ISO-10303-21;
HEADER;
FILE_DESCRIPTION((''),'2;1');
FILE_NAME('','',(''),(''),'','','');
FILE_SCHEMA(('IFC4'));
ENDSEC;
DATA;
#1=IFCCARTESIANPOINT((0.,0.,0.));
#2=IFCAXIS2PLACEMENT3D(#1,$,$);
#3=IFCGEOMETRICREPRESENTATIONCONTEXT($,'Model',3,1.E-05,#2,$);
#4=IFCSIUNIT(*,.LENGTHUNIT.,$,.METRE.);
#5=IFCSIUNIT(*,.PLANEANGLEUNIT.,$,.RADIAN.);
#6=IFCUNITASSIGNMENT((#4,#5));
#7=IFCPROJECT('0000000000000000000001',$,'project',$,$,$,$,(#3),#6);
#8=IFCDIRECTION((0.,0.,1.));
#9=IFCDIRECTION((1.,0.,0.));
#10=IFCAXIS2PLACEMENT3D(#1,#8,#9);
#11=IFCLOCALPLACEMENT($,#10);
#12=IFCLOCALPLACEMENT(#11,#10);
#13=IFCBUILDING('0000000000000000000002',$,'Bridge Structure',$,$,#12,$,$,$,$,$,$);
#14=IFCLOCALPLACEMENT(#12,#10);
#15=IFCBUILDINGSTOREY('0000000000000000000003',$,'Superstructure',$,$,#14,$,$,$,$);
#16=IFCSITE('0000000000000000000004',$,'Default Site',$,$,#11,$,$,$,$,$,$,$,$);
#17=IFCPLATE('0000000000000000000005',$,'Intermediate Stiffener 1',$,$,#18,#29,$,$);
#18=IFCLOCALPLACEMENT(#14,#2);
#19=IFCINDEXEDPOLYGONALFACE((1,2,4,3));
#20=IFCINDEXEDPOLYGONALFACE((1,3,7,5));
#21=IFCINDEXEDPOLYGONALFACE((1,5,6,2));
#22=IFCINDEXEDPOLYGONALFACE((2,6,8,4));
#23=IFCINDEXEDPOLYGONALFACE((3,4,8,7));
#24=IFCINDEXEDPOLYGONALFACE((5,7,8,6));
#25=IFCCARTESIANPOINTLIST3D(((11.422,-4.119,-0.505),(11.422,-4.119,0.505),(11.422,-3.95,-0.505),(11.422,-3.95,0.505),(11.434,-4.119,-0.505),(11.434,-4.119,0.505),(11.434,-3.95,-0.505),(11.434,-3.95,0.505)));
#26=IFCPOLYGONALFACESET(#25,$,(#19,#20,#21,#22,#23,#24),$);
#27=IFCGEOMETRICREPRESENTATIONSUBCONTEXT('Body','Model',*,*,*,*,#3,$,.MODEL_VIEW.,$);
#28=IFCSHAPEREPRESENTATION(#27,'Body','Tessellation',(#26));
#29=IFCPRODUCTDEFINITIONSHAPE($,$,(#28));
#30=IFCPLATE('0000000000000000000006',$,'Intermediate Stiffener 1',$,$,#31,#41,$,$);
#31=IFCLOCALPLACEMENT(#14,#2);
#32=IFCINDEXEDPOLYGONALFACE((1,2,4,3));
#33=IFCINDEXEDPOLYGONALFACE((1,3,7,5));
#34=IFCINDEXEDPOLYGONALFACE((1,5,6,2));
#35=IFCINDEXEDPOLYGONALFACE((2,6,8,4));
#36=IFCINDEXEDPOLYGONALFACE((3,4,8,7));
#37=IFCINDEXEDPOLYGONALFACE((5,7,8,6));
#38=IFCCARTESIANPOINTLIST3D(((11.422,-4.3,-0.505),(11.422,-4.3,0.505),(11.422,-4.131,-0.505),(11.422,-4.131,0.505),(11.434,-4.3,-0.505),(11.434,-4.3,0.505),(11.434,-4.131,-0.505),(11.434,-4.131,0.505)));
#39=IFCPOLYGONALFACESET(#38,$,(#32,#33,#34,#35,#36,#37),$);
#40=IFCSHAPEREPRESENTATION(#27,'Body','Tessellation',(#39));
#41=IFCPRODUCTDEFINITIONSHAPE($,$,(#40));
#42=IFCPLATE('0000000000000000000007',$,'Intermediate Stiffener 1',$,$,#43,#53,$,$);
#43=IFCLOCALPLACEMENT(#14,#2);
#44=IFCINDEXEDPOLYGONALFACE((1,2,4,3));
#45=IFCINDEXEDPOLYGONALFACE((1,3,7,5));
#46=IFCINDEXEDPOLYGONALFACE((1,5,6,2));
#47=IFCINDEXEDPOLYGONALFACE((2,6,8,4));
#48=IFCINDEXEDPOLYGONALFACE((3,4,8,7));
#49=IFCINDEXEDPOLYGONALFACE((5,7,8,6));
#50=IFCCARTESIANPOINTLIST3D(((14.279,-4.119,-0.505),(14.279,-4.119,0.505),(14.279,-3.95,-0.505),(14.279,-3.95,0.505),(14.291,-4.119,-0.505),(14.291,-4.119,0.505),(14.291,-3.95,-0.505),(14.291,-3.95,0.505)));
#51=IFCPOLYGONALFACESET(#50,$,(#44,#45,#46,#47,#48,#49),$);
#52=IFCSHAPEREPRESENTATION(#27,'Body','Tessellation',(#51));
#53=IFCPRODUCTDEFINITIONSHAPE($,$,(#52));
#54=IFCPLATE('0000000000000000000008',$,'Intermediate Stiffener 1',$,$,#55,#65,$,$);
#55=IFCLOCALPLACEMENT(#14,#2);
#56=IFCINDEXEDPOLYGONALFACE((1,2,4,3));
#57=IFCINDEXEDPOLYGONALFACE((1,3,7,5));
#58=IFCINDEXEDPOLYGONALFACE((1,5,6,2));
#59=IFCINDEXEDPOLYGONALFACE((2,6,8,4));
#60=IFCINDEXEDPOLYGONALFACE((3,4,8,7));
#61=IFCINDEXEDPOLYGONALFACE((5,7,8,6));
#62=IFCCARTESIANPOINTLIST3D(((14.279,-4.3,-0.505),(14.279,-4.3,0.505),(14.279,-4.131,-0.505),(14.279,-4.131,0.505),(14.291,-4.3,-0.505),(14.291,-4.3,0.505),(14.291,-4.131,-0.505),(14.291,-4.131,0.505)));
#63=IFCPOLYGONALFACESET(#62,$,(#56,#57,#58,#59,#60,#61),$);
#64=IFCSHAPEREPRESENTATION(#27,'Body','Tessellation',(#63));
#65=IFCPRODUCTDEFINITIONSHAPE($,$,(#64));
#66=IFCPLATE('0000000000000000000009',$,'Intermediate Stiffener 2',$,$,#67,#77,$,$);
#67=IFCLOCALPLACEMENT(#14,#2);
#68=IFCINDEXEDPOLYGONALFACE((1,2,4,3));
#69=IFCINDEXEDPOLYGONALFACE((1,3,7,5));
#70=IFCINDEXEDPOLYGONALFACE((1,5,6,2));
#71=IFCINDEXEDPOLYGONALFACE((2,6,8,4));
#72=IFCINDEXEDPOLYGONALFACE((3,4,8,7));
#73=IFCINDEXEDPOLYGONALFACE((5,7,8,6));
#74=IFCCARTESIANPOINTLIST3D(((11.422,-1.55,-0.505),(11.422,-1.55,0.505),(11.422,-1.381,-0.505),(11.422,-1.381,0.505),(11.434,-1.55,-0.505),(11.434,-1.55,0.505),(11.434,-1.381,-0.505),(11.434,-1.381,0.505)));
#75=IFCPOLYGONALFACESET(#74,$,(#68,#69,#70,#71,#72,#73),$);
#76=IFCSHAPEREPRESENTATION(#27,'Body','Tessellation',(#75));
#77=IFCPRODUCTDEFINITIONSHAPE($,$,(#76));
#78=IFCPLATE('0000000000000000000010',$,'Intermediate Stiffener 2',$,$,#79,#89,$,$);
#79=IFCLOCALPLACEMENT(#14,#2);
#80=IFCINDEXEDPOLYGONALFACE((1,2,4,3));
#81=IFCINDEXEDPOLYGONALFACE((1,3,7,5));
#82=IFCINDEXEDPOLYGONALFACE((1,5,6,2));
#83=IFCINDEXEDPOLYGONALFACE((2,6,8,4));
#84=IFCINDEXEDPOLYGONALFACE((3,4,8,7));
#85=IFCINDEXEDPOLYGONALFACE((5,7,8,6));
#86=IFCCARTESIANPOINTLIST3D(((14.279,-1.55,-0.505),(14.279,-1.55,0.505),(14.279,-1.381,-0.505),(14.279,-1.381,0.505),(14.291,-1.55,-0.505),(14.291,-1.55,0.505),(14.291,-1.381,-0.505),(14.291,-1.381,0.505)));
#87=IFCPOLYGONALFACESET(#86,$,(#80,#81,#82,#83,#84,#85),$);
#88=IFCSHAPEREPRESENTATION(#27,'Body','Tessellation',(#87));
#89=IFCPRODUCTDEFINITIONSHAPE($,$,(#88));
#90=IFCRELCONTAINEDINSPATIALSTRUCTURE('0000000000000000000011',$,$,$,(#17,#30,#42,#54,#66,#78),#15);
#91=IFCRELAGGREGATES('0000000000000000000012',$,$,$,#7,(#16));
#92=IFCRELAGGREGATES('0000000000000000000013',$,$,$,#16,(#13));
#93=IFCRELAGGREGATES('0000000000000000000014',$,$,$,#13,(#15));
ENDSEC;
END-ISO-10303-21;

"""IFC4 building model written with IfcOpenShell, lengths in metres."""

from ifc_helpers import new_model, si_unit, frame, origin, origin_with_axes, origin_2d_with_axis, place, context, subcontext, project, spatial, rectangle, extrude, element, save


model = new_model("IFC4")

# Units and contexts
model_context = context("Model", 3, precision=1e-05, world=origin())
body_context = subcontext(model_context, "Body", "Model", "MODEL_VIEW")
ifc_project = project(units=[si_unit("LENGTHUNIT", "METRE"), si_unit("PLANEANGLEUNIT", "RADIAN")], contexts=[model_context])

# Site, building, storey
site_placement = place(None, origin_with_axes())
site = spatial("IfcSite", under=ifc_project, at=site_placement, Name="Default Site")
building_placement = place(site_placement, origin_with_axes())
building = spatial("IfcBuilding", under=site, at=building_placement, Name="Bridge Structure")
storey_placement = place(building_placement, origin_with_axes())
storey = spatial("IfcBuildingStorey", under=building, at=storey_placement, Name="Superstructure")

# Plates
for number, where, z_axis, x_axis, name in (
    (1, (11.428, -4.0345, -0.505), (0.0, 0.0, 1.0), (1.0, 0.0, 0.0), "Intermediate Stiffener 1"),
    (2, (11.428, -4.2155, -0.505), (0.0, 0.0, 1.0), (1.0, 0.0, 0.0), "Intermediate Stiffener 1"),
    (3, (14.285, -4.0345, -0.505), (0.0, 0.0, 1.0), (1.0, 0.0, 0.0), "Intermediate Stiffener 1"),
    (4, (14.285, -4.2155, -0.505), (0.0, 0.0, 1.0), (1.0, 0.0, 0.0), "Intermediate Stiffener 1"),
    (5, (11.428, -1.4655, -0.505), (0.0, 0.0, 1.0), (1.0, 0.0, 0.0), "Intermediate Stiffener 2"),
    (6, (14.285, -1.4655, -0.505), (0.0, 0.0, 1.0), (1.0, 0.0, 0.0), "Intermediate Stiffener 2"),
):
    element("IfcPlate", number, at=place(storey_placement, frame(where, z_axis=z_axis, x_axis=x_axis)), inside=storey, Name=name, context=body_context, shape_type="SweptSolid", body=[
        extrude(rectangle(XDim=0.012, YDim=0.169, at=origin_2d_with_axis()), origin_with_axes(), (0.0, 0.0, 1.0), 1.01),
    ])

save(model, "model.ifc")
